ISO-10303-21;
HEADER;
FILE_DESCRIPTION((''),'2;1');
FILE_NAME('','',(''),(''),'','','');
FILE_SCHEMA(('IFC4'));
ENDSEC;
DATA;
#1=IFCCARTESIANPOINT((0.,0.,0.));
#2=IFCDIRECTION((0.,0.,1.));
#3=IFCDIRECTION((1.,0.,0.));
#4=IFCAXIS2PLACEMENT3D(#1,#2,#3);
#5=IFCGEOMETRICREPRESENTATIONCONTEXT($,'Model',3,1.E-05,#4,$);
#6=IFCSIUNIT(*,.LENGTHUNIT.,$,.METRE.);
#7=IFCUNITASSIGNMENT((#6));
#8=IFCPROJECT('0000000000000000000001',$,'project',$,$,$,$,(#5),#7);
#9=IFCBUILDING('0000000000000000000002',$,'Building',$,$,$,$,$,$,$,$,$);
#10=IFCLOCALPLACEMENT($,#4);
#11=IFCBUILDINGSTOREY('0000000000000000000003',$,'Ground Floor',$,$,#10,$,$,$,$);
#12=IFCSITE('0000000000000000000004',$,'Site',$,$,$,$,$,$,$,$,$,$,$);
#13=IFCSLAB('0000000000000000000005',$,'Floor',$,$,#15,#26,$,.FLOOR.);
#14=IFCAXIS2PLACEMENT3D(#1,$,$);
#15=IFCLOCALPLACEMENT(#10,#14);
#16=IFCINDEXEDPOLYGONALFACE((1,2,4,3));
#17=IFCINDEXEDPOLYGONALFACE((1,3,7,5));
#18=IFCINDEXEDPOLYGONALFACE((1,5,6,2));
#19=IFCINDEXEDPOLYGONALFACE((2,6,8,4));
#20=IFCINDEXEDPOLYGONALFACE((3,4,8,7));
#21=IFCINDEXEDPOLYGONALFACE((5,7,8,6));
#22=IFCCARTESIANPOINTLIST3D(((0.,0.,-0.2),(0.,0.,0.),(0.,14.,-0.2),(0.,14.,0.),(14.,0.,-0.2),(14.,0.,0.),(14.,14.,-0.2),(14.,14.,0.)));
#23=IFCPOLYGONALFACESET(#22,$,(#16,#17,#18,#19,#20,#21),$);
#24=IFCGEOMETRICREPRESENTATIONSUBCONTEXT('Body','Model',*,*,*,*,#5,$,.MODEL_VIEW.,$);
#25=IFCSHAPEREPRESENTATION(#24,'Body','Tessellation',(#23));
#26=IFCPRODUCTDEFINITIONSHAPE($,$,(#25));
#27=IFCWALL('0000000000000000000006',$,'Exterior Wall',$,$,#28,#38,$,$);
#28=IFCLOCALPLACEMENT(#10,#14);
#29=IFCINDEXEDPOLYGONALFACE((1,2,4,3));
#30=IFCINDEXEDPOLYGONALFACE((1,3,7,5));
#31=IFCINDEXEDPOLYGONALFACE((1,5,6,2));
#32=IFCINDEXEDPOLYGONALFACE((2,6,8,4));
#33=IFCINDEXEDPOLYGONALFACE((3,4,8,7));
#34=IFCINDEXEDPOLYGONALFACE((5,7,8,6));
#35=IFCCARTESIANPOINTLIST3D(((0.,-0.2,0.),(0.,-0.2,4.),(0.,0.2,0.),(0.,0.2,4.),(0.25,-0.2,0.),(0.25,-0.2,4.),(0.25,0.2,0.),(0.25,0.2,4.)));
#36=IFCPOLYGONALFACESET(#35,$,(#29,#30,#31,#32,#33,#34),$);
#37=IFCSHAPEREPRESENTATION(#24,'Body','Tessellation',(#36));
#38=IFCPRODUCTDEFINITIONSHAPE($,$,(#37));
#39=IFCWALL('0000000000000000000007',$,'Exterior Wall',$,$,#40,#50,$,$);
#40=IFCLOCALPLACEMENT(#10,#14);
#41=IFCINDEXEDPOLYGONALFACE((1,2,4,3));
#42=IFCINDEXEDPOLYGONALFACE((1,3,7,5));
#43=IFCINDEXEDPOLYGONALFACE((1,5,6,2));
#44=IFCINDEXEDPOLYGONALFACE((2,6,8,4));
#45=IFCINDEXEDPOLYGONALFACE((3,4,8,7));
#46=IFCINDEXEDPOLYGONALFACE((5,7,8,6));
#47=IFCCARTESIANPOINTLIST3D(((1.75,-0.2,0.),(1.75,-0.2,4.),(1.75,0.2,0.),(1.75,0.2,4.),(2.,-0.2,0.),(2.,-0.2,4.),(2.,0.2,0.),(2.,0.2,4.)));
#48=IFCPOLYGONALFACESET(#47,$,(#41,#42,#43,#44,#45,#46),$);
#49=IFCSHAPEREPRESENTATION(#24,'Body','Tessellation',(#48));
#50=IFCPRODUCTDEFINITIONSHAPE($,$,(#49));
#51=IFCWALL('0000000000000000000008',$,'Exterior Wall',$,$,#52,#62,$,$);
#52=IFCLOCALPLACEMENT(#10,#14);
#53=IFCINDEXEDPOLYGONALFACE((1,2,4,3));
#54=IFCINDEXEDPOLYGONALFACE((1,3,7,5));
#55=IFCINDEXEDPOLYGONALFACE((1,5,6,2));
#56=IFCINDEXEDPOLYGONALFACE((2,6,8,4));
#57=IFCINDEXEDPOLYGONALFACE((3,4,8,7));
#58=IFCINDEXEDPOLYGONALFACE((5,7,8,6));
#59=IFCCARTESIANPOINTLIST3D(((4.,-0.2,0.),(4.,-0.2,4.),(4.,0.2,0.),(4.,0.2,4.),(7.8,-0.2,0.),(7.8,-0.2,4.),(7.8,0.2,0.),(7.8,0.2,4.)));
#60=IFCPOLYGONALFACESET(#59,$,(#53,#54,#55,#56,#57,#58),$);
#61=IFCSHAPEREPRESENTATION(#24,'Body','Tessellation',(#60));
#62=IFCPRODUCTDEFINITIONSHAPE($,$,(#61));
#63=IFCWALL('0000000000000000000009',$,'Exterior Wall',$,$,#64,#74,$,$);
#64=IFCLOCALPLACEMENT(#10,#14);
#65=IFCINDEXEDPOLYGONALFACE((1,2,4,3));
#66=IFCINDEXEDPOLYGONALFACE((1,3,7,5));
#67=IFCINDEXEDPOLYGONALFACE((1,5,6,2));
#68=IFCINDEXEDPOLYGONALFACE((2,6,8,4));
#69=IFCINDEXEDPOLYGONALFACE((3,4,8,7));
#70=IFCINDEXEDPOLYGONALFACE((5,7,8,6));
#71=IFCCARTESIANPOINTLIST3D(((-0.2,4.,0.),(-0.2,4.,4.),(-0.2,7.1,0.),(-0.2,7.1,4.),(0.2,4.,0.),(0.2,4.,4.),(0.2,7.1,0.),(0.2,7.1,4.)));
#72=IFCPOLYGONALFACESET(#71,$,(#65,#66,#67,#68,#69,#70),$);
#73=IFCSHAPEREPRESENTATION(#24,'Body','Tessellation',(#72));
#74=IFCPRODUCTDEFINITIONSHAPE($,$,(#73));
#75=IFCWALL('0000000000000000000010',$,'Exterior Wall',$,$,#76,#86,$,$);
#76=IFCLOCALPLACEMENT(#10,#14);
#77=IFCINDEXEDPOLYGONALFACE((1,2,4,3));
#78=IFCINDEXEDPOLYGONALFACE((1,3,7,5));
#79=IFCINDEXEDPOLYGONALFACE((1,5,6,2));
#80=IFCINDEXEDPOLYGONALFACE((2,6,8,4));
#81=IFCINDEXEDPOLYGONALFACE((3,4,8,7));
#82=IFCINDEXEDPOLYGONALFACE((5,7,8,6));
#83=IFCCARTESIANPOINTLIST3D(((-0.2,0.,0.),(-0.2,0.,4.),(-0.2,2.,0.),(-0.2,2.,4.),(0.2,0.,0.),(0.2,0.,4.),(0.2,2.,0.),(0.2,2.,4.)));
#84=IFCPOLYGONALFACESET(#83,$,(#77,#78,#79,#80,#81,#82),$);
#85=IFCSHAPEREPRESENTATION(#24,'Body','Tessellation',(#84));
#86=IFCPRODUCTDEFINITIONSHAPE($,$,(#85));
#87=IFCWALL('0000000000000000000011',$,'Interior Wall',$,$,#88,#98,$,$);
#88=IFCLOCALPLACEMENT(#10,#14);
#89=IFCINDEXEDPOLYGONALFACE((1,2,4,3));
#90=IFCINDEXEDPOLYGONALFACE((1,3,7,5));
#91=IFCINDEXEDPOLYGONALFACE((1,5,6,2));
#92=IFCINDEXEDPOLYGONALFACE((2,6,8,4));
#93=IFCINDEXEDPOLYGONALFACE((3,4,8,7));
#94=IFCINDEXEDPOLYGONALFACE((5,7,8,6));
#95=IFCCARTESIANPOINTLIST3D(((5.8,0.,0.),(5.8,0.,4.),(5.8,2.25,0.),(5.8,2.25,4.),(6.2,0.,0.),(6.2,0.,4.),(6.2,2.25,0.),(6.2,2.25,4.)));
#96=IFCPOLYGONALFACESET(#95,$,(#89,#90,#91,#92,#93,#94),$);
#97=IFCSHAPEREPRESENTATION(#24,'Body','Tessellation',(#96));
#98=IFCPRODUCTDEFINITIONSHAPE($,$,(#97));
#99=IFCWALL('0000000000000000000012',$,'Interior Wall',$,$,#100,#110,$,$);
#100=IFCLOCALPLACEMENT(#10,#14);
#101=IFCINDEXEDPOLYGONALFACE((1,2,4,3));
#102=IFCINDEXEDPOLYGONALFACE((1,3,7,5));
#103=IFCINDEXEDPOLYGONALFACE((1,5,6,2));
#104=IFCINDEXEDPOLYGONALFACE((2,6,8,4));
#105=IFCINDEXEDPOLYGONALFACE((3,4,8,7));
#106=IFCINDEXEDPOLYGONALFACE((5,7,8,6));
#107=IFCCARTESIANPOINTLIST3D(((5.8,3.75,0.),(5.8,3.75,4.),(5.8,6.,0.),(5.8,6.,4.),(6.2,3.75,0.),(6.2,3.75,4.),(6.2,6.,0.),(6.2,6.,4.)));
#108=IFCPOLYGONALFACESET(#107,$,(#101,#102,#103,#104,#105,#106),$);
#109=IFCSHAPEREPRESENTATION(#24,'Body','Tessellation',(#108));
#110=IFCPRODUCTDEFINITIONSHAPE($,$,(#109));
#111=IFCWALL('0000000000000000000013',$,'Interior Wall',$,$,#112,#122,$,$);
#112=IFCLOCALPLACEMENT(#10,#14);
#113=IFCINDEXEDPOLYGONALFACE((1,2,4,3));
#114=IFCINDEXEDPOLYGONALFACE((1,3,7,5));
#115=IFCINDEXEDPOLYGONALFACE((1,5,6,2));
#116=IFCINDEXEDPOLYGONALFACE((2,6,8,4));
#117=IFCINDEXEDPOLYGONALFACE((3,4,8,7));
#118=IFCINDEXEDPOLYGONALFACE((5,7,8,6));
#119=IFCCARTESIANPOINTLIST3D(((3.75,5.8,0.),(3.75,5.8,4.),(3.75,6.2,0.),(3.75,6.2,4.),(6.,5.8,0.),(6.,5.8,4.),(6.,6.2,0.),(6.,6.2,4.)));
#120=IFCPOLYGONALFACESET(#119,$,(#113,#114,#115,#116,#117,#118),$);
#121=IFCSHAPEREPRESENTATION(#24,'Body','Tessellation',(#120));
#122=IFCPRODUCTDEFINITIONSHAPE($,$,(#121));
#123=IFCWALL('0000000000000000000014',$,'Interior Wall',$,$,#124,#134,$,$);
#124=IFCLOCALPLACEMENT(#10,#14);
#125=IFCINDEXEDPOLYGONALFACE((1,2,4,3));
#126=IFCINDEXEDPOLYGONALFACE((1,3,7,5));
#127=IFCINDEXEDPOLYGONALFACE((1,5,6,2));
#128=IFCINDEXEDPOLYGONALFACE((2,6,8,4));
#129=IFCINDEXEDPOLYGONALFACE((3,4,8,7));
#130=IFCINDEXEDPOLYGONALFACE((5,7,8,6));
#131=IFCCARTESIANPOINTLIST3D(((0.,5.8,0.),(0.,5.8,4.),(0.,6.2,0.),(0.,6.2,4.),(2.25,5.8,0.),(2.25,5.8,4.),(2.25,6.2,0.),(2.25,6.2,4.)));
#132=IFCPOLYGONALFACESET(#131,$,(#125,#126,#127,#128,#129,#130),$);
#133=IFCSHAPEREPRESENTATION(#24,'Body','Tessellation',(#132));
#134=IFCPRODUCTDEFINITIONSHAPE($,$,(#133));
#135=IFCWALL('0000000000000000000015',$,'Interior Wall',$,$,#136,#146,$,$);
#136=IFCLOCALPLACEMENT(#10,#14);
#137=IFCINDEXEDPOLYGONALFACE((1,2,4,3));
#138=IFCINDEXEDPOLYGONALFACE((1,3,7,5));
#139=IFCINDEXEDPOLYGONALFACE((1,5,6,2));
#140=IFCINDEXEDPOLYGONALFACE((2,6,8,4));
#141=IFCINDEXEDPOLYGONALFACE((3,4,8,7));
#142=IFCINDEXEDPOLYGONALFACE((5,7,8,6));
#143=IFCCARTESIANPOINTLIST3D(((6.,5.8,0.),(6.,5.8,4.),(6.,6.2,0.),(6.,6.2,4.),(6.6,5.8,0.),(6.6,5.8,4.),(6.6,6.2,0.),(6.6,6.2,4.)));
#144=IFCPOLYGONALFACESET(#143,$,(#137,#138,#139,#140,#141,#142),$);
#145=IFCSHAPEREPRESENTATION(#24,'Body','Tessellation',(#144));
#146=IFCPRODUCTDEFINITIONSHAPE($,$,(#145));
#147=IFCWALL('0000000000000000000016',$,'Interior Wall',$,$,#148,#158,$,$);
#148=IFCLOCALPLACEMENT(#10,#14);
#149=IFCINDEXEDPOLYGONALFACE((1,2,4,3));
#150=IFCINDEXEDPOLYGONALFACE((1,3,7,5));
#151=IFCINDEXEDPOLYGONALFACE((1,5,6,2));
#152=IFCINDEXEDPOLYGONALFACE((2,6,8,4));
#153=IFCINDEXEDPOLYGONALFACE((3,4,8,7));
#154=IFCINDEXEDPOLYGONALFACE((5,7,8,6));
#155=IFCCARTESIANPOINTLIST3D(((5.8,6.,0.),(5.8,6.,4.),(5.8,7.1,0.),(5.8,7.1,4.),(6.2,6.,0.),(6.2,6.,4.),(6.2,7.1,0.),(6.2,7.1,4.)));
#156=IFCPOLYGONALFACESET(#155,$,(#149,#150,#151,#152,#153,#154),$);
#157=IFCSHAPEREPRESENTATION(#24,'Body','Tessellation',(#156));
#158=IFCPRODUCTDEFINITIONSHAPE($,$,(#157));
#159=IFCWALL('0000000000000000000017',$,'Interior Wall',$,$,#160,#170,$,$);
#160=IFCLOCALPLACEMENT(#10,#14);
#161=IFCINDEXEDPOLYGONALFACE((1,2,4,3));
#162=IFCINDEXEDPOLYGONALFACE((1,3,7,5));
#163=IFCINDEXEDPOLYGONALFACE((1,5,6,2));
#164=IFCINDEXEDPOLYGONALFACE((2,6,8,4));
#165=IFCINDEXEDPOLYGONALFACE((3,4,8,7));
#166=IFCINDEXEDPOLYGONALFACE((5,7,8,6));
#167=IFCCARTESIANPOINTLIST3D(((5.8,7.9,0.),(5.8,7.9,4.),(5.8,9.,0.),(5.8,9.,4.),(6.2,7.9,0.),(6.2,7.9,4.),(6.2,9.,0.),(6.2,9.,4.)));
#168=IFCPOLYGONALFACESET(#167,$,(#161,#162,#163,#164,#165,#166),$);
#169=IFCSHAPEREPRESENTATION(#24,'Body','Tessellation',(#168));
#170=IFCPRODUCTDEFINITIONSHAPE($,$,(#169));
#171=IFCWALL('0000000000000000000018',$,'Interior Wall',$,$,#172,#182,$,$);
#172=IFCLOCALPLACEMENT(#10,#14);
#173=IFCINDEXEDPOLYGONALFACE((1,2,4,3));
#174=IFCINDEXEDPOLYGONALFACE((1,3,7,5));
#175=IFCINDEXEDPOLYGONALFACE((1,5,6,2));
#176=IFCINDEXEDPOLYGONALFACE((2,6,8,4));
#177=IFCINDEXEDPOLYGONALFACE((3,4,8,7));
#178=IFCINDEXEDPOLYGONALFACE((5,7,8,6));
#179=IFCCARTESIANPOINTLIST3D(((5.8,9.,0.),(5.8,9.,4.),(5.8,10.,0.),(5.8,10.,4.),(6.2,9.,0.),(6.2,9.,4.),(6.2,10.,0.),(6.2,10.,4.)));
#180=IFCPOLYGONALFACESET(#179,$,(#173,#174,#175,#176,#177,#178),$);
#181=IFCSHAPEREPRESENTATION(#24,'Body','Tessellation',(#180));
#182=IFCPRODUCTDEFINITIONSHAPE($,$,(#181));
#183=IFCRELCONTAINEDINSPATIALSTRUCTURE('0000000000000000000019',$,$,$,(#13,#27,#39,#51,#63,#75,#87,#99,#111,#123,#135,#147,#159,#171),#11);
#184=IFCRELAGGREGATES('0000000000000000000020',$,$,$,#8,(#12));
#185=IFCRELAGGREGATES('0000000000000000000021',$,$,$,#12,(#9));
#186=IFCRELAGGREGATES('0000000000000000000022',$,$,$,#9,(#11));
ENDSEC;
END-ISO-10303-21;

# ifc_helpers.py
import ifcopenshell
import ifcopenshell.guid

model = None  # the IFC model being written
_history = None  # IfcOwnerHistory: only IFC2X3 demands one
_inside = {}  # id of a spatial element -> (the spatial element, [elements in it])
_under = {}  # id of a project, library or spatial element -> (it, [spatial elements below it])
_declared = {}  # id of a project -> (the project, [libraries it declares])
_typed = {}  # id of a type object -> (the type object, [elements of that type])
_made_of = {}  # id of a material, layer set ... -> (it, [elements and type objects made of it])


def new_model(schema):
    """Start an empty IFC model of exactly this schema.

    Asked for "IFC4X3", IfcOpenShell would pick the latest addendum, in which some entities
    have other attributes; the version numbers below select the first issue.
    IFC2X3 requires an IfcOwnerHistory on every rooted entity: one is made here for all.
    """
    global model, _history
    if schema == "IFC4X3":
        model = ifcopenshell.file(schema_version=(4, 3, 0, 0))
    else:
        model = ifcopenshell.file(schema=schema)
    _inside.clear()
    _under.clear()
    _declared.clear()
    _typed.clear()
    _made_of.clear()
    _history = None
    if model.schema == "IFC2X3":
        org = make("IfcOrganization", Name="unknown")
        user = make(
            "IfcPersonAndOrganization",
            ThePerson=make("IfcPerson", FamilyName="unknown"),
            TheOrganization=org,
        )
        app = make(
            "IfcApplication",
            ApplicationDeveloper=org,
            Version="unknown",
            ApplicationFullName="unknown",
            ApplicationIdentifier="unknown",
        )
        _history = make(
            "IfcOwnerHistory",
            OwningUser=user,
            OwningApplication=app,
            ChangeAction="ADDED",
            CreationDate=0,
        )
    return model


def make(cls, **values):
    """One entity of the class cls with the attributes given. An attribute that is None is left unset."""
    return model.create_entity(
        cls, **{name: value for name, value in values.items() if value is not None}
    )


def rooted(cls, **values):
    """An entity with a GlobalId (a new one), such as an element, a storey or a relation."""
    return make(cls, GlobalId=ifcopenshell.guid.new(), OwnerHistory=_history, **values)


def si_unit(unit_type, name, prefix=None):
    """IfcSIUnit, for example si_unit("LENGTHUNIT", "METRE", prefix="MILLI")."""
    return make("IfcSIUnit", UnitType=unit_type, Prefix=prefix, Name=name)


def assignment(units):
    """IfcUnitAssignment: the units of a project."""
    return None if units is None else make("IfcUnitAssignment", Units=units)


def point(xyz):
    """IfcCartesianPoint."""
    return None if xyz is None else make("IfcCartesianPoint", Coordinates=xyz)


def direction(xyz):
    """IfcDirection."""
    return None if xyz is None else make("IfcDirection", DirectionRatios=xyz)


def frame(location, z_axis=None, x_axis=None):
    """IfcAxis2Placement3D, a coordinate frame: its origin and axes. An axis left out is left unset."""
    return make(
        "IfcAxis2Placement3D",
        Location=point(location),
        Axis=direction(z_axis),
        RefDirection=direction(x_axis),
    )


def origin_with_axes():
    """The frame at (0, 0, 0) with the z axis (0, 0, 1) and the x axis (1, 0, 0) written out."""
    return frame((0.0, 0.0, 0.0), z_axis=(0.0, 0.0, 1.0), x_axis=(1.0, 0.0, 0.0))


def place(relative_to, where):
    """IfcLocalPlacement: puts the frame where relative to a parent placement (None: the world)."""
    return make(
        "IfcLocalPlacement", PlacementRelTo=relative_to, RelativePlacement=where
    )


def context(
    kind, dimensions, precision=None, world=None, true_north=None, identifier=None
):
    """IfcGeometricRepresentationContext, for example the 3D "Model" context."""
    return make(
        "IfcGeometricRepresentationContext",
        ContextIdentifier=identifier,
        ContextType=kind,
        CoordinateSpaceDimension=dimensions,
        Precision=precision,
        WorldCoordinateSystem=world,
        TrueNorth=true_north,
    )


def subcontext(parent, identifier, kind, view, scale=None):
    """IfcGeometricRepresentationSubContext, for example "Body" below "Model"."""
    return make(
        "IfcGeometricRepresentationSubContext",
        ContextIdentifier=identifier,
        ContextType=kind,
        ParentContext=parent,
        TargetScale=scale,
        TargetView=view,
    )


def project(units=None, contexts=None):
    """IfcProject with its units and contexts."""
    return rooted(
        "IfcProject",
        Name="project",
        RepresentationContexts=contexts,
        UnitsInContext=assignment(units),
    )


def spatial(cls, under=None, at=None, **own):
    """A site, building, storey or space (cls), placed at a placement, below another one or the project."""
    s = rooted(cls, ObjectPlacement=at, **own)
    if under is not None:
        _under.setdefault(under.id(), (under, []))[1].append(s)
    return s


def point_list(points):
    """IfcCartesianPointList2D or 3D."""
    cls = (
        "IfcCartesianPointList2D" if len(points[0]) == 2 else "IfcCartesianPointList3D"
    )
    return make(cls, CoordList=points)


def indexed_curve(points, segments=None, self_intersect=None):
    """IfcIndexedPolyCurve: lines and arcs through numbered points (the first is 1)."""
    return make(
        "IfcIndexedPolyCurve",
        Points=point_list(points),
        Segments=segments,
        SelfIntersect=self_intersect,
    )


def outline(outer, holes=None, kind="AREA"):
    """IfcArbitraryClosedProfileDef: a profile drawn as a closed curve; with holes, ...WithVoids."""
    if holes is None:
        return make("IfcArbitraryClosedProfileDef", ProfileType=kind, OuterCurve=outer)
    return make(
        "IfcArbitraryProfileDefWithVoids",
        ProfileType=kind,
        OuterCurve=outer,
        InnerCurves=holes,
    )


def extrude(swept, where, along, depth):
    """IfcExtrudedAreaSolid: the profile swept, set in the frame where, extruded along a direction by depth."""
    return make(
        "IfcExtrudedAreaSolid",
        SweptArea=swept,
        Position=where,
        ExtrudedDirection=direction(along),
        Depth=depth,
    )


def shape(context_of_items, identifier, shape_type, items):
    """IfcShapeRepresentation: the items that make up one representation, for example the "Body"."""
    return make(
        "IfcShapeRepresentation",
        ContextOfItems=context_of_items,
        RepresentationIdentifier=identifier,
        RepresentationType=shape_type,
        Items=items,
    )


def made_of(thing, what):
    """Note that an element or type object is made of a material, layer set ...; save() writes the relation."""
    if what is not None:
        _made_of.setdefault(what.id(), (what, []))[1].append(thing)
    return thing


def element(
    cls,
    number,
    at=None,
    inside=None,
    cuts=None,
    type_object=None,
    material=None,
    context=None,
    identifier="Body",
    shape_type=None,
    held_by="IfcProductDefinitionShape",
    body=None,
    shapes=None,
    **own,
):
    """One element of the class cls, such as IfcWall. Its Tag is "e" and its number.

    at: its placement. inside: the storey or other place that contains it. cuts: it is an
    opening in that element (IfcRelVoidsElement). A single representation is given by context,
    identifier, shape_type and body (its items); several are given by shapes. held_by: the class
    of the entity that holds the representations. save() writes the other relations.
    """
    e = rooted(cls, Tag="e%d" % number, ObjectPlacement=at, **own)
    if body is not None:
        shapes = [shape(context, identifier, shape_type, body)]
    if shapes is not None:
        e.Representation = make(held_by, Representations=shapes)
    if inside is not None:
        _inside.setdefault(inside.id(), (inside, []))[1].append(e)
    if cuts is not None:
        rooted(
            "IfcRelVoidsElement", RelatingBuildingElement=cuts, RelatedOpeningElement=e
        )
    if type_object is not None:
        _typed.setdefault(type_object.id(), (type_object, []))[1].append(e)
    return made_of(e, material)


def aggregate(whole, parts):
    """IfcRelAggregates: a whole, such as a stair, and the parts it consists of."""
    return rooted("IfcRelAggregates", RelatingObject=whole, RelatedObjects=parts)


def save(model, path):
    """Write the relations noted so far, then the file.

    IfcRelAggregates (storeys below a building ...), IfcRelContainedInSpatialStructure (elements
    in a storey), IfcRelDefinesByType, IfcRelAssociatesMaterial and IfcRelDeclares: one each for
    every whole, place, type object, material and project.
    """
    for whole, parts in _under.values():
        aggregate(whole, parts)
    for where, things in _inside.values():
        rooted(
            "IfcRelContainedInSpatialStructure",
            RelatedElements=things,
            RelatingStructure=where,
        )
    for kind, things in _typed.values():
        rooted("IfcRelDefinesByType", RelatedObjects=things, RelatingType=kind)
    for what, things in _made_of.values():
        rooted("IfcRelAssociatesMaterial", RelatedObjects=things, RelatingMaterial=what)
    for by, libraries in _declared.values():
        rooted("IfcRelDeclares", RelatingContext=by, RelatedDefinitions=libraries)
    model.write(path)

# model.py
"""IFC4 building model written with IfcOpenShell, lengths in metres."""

from ifc_helpers import new_model, si_unit, frame, origin_with_axes, place, context, subcontext, project, spatial, indexed_curve, outline, extrude, element, save


model = new_model("IFC4")

# Units and contexts
model_context = context("Model", 3, precision=1e-05, world=origin_with_axes())
body_context = subcontext(model_context, "Body", "Model", "MODEL_VIEW")
ifc_project = project(units=[si_unit("LENGTHUNIT", "METRE")], contexts=[model_context])

# Site, building, storey
site = spatial("IfcSite", under=ifc_project, Name="Site")
building = spatial("IfcBuilding", under=site, Name="Building")
storey_placement = place(None, origin_with_axes())
storey = spatial("IfcBuildingStorey", under=building, at=storey_placement, Name="Ground Floor")

# Slab
slab_placement = place(storey_placement, frame((0.0, 0.0, -0.2), z_axis=(0.0, 0.0, 1.0), x_axis=(1.0, 0.0, 0.0)))
element("IfcSlab", 1, at=slab_placement, inside=storey, Name="Floor", PredefinedType="FLOOR", context=body_context, shape_type="SweptSolid", body=[
    extrude(outline(indexed_curve([(0.0, 0.0), (14.0, 0.0), (14.0, 14.0), (0.0, 14.0)])), None, (0.0, 0.0, 1.0), 0.2),
])

# Walls
for number, where, z_axis, x_axis, name in (
    (2, (0.0, 0.0, 0.0), (0.0, 0.0, 1.0), (1.0, 0.0, 0.0), "Exterior Wall"),
    (3, (1.75, 0.0, 0.0), (0.0, 0.0, 1.0), (1.0, 0.0, 0.0), "Exterior Wall"),
):
    element("IfcWall", number, at=place(storey_placement, frame(where, z_axis=z_axis, x_axis=x_axis)), inside=storey, Name=name, context=body_context, shape_type="SweptSolid", body=[
        extrude(outline(indexed_curve([(0.0, 0.0), (0.0, 0.4), (0.25, 0.4), (0.25, 0.0), (0.0, 0.0)], self_intersect=False)), frame((0.0, -0.2, 0.0), z_axis=(0.0, 0.0, 1.0), x_axis=(1.0, 0.0, 0.0)), (0.0, 0.0, 1.0), 4.0),
    ])
wall_1_placement = place(storey_placement, frame((4.0, 0.0, 0.0), z_axis=(0.0, 0.0, 1.0), x_axis=(1.0, 0.0, 0.0)))
element("IfcWall", 4, at=wall_1_placement, inside=storey, Name="Exterior Wall", context=body_context, shape_type="SweptSolid", body=[
    extrude(outline(indexed_curve([(0.0, 0.0), (0.0, 0.4), (3.8, 0.4), (3.8, 0.0), (0.0, 0.0)], self_intersect=False)), frame((0.0, -0.2, 0.0), z_axis=(0.0, 0.0, 1.0), x_axis=(1.0, 0.0, 0.0)), (0.0, 0.0, 1.0), 4.0),
])
wall_2_placement = place(storey_placement, frame((0.0, 7.1, 0.0), z_axis=(0.0, 0.0, 1.0), x_axis=(0.0, -1.0, 0.0)))
element("IfcWall", 5, at=wall_2_placement, inside=storey, Name="Exterior Wall", context=body_context, shape_type="SweptSolid", body=[
    extrude(outline(indexed_curve([(0.0, 0.0), (0.0, 0.4), (3.1, 0.4), (3.1, 0.0), (0.0, 0.0)], self_intersect=False)), frame((0.0, -0.2, 0.0), z_axis=(0.0, 0.0, 1.0), x_axis=(1.0, 0.0, 0.0)), (0.0, 0.0, 1.0), 4.0),
])
wall_3_placement = place(storey_placement, frame((0.0, 2.0, 0.0), z_axis=(0.0, 0.0, 1.0), x_axis=(0.0, -1.0, 0.0)))
element("IfcWall", 6, at=wall_3_placement, inside=storey, Name="Exterior Wall", context=body_context, shape_type="SweptSolid", body=[
    extrude(outline(indexed_curve([(0.0, 0.0), (0.0, 0.4), (2.0, 0.4), (2.0, 0.0), (0.0, 0.0)], self_intersect=False)), frame((0.0, -0.2, 0.0), z_axis=(0.0, 0.0, 1.0), x_axis=(1.0, 0.0, 0.0)), (0.0, 0.0, 1.0), 4.0),
])
for number, where, z_axis, x_axis, name in (
    (7, (6.0, 0.0, 0.0), (0.0, 0.0, 1.0), (0.0, 1.0, 0.0), "Interior Wall"),
    (8, (6.0, 3.75, 0.0), (0.0, 0.0, 1.0), (0.0, 1.0, 0.0), "Interior Wall"),
    (9, (6.0, 6.0, 0.0), (0.0, 0.0, 1.0), (-1.0, 0.0, 0.0), "Interior Wall"),
    (10, (2.25, 6.0, 0.0), (0.0, 0.0, 1.0), (-1.0, 0.0, 0.0), "Interior Wall"),
):
    element("IfcWall", number, at=place(storey_placement, frame(where, z_axis=z_axis, x_axis=x_axis)), inside=storey, Name=name, context=body_context, shape_type="SweptSolid", body=[
        extrude(outline(indexed_curve([(0.0, 0.0), (0.0, 0.4), (2.25, 0.4), (2.25, 0.0), (0.0, 0.0)], self_intersect=False)), frame((0.0, -0.2, 0.0), z_axis=(0.0, 0.0, 1.0), x_axis=(1.0, 0.0, 0.0)), (0.0, 0.0, 1.0), 4.0),
    ])
wall_4_placement = place(storey_placement, frame((6.6, 6.0, 0.0), z_axis=(0.0, 0.0, 1.0), x_axis=(-1.0, 0.0, 0.0)))
element("IfcWall", 11, at=wall_4_placement, inside=storey, Name="Interior Wall", context=body_context, shape_type="SweptSolid", body=[
    extrude(outline(indexed_curve([(0.0, 0.0), (0.0, 0.4), (0.6, 0.4), (0.6, 0.0), (0.0, 0.0)], self_intersect=False)), frame((0.0, -0.2, 0.0), z_axis=(0.0, 0.0, 1.0), x_axis=(1.0, 0.0, 0.0)), (0.0, 0.0, 1.0), 4.0),
])
for number, where, z_axis, x_axis, name in (
    (12, (6.0, 6.0, 0.0), (0.0, 0.0, 1.0), (0.0, 1.0, 0.0), "Interior Wall"),
    (13, (6.0, 7.9, 0.0), (0.0, 0.0, 1.0), (0.0, 1.0, 0.0), "Interior Wall"),
):
    element("IfcWall", number, at=place(storey_placement, frame(where, z_axis=z_axis, x_axis=x_axis)), inside=storey, Name=name, context=body_context, shape_type="SweptSolid", body=[
        extrude(outline(indexed_curve([(0.0, 0.0), (0.0, 0.4), (1.1, 0.4), (1.1, 0.0), (0.0, 0.0)], self_intersect=False)), frame((0.0, -0.2, 0.0), z_axis=(0.0, 0.0, 1.0), x_axis=(1.0, 0.0, 0.0)), (0.0, 0.0, 1.0), 4.0),
    ])
wall_5_placement = place(storey_placement, frame((6.0, 9.0, 0.0), z_axis=(0.0, 0.0, 1.0), x_axis=(0.0, 1.0, 0.0)))
element("IfcWall", 14, at=wall_5_placement, inside=storey, Name="Interior Wall", context=body_context, shape_type="SweptSolid", body=[
    extrude(outline(indexed_curve([(0.0, 0.0), (0.0, 0.4), (1.0, 0.4), (1.0, 0.0), (0.0, 0.0)], self_intersect=False)), frame((0.0, -0.2, 0.0), z_axis=(0.0, 0.0, 1.0), x_axis=(1.0, 0.0, 0.0)), (0.0, 0.0, 1.0), 4.0),
])

save(model, "model.ifc")
